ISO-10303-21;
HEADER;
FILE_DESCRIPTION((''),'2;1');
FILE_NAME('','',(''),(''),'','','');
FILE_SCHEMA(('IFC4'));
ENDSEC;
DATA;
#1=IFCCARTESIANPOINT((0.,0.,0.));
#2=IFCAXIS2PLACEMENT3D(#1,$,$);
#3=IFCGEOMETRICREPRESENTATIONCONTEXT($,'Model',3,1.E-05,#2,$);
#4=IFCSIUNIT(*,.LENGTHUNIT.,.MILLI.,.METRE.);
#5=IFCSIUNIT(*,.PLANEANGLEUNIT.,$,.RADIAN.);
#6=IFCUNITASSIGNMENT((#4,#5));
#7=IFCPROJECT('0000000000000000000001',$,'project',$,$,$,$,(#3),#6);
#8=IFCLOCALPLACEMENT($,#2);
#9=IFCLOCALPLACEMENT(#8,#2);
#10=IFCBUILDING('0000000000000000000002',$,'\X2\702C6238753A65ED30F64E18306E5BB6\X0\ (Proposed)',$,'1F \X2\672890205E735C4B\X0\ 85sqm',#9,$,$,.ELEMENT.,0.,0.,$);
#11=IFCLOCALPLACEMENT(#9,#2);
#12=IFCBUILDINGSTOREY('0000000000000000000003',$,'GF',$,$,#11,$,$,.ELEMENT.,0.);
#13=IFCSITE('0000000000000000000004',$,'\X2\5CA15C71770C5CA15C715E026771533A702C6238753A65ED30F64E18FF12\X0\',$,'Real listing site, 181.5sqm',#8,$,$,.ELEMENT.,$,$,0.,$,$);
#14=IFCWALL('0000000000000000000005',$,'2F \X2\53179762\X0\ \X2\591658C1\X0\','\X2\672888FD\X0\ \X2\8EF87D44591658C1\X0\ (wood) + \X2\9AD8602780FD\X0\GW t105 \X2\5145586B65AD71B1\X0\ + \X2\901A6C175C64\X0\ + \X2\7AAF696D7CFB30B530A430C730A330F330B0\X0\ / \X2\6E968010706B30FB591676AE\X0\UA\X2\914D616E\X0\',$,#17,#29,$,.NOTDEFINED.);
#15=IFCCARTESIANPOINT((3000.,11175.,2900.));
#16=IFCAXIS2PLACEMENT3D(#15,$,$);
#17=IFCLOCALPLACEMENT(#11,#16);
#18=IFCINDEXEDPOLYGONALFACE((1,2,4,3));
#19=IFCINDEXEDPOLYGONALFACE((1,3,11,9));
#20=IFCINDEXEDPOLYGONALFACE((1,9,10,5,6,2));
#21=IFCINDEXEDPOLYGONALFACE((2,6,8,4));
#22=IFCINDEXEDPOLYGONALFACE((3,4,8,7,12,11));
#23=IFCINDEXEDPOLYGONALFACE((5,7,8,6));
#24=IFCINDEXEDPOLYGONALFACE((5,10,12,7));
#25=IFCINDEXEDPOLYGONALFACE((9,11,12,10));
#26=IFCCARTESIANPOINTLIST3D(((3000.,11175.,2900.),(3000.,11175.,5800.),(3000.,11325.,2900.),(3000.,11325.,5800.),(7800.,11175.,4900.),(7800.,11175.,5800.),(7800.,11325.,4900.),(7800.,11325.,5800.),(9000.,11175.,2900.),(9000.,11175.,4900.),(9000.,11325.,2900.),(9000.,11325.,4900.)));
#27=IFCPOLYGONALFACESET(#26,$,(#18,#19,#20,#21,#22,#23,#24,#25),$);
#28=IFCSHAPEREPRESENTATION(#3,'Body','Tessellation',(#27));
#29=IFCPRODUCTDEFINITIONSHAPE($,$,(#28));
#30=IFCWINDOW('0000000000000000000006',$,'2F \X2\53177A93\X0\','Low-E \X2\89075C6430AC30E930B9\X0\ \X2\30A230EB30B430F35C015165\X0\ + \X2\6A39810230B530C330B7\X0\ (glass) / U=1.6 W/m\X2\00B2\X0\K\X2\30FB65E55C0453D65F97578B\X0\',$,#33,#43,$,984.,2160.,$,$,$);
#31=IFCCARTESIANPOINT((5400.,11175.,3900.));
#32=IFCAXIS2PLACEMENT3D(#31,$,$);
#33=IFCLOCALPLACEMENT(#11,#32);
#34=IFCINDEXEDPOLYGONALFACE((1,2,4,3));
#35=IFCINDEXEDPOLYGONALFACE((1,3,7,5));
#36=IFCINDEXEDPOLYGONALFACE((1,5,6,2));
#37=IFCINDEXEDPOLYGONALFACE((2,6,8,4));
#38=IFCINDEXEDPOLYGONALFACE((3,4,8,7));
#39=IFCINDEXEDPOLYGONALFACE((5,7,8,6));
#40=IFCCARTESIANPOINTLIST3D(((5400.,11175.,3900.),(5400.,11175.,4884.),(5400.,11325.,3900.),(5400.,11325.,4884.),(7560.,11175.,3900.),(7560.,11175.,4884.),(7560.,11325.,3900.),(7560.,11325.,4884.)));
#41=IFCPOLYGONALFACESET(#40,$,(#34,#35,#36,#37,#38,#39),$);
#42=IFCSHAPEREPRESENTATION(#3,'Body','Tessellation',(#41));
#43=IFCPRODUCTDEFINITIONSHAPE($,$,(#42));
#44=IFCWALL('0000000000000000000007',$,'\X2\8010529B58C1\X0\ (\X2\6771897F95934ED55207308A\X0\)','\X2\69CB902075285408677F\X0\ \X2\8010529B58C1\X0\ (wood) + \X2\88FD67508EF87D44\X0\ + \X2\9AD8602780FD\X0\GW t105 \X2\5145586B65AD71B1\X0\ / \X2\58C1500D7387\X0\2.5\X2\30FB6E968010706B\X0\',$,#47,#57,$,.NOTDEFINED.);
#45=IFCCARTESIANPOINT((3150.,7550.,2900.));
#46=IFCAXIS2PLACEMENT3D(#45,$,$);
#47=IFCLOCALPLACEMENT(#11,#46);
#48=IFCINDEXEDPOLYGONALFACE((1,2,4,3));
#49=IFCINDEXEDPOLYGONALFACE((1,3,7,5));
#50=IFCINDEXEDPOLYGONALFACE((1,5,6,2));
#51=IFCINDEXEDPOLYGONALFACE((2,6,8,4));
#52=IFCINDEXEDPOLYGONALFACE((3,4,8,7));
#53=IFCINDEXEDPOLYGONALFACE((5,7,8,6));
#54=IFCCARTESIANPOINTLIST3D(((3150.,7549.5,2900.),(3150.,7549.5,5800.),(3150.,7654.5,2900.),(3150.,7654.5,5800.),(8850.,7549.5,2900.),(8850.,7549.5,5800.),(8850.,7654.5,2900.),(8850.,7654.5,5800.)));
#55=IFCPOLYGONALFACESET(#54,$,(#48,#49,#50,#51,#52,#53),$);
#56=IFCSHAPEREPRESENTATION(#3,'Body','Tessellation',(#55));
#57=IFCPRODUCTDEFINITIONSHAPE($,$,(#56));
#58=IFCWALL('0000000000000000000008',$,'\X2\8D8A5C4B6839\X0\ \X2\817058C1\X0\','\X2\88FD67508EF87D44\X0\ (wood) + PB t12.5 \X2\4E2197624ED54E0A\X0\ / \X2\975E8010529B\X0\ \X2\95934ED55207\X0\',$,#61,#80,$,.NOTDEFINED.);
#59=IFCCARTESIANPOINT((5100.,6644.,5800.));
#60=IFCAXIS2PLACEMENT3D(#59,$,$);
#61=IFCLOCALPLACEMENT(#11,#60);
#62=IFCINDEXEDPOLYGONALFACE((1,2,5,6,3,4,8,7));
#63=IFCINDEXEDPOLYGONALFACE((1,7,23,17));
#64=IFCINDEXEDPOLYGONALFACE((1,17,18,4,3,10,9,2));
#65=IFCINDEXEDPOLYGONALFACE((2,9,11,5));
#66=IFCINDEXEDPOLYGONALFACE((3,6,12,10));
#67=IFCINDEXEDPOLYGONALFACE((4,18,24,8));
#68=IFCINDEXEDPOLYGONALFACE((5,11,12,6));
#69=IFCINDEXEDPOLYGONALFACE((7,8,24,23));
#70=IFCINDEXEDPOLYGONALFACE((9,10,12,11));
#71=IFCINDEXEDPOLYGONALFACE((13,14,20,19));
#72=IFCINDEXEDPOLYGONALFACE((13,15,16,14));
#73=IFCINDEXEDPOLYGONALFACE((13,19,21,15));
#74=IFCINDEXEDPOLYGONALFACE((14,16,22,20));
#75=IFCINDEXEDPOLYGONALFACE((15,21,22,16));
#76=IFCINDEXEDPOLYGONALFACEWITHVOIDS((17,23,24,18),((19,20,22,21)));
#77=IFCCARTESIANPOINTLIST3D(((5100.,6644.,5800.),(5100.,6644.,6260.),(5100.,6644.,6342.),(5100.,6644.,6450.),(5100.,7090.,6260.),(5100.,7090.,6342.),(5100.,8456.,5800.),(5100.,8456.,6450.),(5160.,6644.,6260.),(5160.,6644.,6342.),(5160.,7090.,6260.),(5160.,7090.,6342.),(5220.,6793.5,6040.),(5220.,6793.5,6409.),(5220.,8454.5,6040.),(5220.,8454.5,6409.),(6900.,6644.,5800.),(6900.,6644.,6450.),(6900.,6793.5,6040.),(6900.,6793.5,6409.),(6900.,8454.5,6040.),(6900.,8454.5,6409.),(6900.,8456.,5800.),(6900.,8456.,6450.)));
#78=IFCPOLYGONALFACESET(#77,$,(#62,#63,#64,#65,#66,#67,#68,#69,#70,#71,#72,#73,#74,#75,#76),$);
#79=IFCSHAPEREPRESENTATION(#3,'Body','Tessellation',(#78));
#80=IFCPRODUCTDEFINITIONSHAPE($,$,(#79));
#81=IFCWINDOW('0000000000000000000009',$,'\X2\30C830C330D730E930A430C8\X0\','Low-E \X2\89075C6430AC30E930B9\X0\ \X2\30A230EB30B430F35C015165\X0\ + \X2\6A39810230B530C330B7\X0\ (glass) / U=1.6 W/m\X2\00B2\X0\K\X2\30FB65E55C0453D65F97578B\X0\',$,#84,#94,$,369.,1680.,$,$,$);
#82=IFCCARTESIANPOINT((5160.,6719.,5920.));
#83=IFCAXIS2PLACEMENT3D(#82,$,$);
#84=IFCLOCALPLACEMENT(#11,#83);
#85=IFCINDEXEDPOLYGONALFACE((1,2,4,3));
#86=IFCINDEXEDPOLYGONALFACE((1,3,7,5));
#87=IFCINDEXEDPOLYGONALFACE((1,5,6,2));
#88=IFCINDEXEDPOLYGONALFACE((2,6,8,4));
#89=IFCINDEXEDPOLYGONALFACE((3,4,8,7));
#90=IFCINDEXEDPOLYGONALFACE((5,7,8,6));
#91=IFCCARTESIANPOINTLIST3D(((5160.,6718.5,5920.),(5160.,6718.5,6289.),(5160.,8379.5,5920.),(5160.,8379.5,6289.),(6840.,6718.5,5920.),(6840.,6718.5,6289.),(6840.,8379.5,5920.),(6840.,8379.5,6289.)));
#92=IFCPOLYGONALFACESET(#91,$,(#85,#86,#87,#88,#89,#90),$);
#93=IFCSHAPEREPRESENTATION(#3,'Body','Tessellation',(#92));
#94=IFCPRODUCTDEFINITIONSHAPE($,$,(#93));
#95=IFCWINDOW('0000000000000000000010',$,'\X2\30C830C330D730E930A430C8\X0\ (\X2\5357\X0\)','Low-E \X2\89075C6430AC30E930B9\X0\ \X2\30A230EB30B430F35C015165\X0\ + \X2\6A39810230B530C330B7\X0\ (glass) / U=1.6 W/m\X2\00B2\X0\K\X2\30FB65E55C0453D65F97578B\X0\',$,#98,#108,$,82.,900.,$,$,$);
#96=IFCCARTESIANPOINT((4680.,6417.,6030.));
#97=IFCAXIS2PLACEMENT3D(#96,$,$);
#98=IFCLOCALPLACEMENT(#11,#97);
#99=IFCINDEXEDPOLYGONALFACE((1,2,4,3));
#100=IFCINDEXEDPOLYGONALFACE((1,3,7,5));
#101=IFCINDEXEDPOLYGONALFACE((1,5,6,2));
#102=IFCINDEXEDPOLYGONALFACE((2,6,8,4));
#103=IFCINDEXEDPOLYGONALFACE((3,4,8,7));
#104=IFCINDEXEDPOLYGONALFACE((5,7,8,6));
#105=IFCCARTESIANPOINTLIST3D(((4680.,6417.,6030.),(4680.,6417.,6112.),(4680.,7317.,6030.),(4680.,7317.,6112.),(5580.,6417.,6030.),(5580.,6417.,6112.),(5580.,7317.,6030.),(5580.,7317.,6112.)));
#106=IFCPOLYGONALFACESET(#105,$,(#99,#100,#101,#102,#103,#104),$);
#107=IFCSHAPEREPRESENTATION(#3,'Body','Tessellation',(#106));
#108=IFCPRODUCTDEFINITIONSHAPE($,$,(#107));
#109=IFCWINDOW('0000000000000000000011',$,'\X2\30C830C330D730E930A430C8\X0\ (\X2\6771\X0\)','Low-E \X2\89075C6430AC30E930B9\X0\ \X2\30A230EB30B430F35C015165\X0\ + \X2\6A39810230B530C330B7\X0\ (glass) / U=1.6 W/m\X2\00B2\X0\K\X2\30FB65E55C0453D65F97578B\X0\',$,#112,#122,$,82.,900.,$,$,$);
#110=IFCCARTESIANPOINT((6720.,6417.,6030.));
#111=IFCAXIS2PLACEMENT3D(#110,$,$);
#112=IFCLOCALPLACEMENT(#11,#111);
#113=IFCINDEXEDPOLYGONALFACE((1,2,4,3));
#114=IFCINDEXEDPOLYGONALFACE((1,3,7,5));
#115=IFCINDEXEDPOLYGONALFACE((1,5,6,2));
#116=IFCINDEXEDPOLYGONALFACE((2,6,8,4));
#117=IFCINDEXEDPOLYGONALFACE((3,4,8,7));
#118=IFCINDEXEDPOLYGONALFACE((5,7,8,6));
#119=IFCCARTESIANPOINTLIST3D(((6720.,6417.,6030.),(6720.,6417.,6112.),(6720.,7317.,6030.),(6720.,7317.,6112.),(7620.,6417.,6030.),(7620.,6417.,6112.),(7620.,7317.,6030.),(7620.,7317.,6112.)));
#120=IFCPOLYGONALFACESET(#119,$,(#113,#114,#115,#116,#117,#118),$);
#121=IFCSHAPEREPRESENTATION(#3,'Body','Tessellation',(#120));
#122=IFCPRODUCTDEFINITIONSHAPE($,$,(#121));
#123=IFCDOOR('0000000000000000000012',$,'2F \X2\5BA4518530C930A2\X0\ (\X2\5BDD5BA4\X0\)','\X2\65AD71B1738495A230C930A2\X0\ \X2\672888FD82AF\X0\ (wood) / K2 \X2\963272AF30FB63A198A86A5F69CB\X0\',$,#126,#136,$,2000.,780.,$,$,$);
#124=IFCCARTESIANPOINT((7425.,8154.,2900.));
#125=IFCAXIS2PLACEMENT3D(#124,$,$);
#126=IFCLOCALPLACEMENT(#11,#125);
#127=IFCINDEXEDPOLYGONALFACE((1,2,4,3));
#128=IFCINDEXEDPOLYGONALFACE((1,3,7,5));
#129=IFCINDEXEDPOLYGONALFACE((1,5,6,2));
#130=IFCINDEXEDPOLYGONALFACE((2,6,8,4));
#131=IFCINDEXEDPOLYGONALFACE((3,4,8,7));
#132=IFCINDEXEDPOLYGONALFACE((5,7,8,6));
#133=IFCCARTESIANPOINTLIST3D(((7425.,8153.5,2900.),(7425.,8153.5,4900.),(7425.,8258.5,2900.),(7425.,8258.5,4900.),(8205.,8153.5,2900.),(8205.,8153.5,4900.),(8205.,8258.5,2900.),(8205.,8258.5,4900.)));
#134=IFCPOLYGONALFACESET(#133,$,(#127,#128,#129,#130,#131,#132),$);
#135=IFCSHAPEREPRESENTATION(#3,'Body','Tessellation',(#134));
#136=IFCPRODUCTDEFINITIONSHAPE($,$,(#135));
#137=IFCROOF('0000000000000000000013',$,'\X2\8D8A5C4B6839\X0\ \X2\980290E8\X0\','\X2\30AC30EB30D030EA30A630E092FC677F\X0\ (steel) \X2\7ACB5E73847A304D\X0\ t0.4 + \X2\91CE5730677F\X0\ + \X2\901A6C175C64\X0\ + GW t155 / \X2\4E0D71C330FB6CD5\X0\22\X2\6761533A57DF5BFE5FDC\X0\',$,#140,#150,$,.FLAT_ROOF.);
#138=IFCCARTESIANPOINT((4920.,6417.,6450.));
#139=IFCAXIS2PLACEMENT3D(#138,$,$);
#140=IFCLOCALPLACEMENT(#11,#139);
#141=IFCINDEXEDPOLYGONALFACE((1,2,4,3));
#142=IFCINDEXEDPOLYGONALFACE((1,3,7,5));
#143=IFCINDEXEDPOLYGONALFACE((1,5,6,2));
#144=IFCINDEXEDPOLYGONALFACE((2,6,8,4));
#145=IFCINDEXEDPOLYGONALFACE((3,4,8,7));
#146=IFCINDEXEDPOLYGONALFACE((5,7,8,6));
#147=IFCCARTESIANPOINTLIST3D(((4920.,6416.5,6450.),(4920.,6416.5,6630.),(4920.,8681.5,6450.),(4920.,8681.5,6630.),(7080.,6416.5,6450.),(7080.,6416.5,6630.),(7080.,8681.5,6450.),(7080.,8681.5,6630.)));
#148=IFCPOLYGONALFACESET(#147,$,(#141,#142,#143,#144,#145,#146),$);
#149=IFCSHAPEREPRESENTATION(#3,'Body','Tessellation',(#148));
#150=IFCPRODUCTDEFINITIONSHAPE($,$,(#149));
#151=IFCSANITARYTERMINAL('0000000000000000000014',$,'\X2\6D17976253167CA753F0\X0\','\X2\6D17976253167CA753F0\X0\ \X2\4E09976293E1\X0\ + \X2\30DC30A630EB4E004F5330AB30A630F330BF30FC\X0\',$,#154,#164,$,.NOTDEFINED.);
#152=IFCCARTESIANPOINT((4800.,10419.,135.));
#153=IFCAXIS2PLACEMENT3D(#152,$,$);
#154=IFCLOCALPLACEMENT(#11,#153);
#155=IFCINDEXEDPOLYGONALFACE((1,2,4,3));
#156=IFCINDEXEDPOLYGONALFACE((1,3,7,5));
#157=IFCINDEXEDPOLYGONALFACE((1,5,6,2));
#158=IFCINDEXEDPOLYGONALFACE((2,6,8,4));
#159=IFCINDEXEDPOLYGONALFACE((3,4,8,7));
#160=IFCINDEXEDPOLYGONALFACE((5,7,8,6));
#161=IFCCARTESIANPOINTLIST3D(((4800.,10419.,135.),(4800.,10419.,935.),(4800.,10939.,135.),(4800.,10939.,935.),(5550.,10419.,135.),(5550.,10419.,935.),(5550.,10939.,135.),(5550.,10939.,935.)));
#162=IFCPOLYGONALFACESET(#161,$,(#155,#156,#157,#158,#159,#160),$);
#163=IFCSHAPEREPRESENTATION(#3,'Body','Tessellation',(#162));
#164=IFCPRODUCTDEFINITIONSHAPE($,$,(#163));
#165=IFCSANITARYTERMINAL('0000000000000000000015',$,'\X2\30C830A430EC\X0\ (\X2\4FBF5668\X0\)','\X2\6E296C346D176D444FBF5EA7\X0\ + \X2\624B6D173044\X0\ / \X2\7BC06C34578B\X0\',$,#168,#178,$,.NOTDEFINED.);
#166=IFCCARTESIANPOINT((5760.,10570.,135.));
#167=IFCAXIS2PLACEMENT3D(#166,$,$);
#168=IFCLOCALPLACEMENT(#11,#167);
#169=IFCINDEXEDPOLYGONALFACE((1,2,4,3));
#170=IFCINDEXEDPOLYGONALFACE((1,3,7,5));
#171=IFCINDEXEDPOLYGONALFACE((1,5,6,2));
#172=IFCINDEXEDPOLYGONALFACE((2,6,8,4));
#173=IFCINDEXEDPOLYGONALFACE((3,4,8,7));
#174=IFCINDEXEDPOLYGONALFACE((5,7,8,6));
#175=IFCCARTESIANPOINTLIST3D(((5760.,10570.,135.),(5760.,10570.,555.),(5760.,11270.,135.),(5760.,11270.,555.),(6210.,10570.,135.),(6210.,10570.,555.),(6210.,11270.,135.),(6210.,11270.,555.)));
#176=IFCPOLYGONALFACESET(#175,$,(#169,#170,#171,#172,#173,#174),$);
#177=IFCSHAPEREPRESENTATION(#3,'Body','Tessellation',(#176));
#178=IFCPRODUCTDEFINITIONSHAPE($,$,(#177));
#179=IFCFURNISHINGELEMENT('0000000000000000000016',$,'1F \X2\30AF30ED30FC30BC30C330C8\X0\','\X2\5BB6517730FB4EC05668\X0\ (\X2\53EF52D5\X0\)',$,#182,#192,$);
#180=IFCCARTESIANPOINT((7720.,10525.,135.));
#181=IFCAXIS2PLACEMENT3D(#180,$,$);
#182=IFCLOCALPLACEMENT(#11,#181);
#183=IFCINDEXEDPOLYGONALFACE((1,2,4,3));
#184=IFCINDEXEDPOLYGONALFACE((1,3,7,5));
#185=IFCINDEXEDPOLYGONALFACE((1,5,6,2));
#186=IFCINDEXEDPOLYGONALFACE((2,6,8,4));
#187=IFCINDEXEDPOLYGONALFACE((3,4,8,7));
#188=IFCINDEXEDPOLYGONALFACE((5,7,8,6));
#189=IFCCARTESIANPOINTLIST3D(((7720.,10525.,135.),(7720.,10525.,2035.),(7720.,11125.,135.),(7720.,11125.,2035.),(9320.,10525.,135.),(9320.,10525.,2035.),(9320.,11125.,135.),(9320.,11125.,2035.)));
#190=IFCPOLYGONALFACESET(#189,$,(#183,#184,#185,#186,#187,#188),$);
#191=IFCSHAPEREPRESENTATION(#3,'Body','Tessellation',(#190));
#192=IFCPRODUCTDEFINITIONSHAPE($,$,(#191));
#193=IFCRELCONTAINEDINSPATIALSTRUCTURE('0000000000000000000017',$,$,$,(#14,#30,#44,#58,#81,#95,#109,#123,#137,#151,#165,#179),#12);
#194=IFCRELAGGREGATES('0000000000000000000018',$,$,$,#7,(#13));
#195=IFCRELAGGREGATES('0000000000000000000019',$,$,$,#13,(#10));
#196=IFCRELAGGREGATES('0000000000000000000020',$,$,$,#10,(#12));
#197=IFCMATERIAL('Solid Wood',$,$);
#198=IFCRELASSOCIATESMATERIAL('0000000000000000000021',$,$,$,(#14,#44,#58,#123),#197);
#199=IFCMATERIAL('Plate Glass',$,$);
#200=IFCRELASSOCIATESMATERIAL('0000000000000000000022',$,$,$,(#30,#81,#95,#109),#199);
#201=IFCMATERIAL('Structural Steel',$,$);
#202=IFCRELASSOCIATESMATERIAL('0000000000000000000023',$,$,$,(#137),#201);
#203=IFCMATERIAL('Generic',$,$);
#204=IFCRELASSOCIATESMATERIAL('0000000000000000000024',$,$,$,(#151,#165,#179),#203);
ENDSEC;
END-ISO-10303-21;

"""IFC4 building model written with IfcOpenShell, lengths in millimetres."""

from ifc_helpers import new_model, si_unit, frame, frame_2d, origin, place, context, project, spatial, rectangle, extrude, material, element, fill, save


model = new_model("IFC4")

# Units and contexts
model_context = context("Model", 3, precision=1e-05, world=origin())
ifc_project = project(units=[si_unit("LENGTHUNIT", "METRE", prefix="MILLI"), si_unit("PLANEANGLEUNIT", "RADIAN")], contexts=[model_context])

# Site, building, storey
site_placement = place(None, origin())
site = spatial("IfcSite", under=ifc_project, at=site_placement, Name="岡山県岡山市東区瀬戸町旭ヶ丘２", ObjectType="Real listing site, 181.5sqm", CompositionType="ELEMENT", RefElevation=0.0)
building_placement = place(site_placement, origin())
building = spatial("IfcBuilding", under=site, at=building_placement, Name="瀬戸町旭ヶ丘の家 (Proposed)", ObjectType="1F 木造平屋 85sqm", CompositionType="ELEMENT", ElevationOfRefHeight=0.0, ElevationOfTerrain=0.0)
storey_placement = place(building_placement, origin())
storey = spatial("IfcBuildingStorey", under=building, at=storey_placement, Name="GF", CompositionType="ELEMENT", Elevation=0.0)

# Wall, opening, window
ifc_material_1 = material(Name="Solid Wood")
wall_1_placement = place(storey_placement, frame((3000.0, 11175.0, 2900.0)))
wall_1 = element("IfcWall", 1, at=wall_1_placement, inside=storey, material=ifc_material_1, Name="2F 北面 外壁", Description="木製 軸組外壁 (wood) + 高性能GW t105 充填断熱 + 通気層 + 窯業系サイディング / 準耐火・外皮UA配慮", PredefinedType="NOTDEFINED", context=model_context, shape_type="SweptSolid", body=[
    extrude(rectangle(XDim=6000.0, YDim=150.0, at=frame_2d((3000.0, 75.0))), frame((3000.0, 11175.0, 2900.0)), (0.0, 0.0, 1.0), 2900.0),
])
opening_1_placement = place(storey_placement, frame((5400.0, 11175.0, 3900.0)))
opening_1 = element("IfcOpeningElement", 2, at=opening_1_placement, cuts=wall_1, PredefinedType="NOTDEFINED", context=model_context, shape_type="SweptSolid", body=[
    extrude(rectangle(XDim=2160.0, YDim=150.0, at=frame_2d((1080.0, 75.0))), frame((5400.0, 11175.0, 3900.0)), (0.0, 0.0, 1.0), 984.0),
])
ifc_material_2 = material(Name="Plate Glass")
window_1_placement = place(storey_placement, frame((5400.0, 11175.0, 3900.0)))
window_1 = element("IfcWindow", 3, at=window_1_placement, inside=storey, material=ifc_material_2, Name="2F 北窓", Description="Low-E 複層ガラス アルゴン封入 + 樹脂サッシ (glass) / U=1.6 W/m²K・日射取得型", OverallHeight=984.0, OverallWidth=2160.0, context=model_context, shape_type="SweptSolid", body=[
    extrude(rectangle(XDim=2160.0, YDim=150.0, at=frame_2d((1080.0, 75.0))), frame((5400.0, 11175.0, 3900.0)), (0.0, 0.0, 1.0), 984.0),
])
fill(opening_1, window_1)

# Wall
wall_2_placement = place(storey_placement, frame((3150.0, 7550.0, 2900.0)))
element("IfcWall", 4, at=wall_2_placement, inside=storey, material=ifc_material_1, Name="耐力壁 (東西間仕切り)", Description="構造用合板 耐力壁 (wood) + 製材軸組 + 高性能GW t105 充填断熱 / 壁倍率2.5・準耐火", PredefinedType="NOTDEFINED", context=model_context, shape_type="SweptSolid", body=[
    extrude(rectangle(XDim=5700.0, YDim=105.0, at=frame_2d((2850.0, 52.0))), frame((3150.0, 7550.0, 2900.0)), (0.0, 0.0, 1.0), 2900.0),
])

# Wall, openings, windows
wall_3_placement = place(storey_placement, frame((5100.0, 6644.0, 5800.0)))
wall_3 = element("IfcWall", 5, at=wall_3_placement, inside=storey, material=ifc_material_1, Name="越屋根 腰壁", Description="製材軸組 (wood) + PB t12.5 両面仕上 / 非耐力 間仕切", PredefinedType="NOTDEFINED", context=model_context, shape_type="SweptSolid", body=[
    extrude(rectangle(XDim=1800.0, YDim=1812.0, at=frame_2d((900.0, 906.0))), frame((5100.0, 6644.0, 5800.0)), (0.0, 0.0, 1.0), 650.0),
])
opening_2_placement = place(storey_placement, frame((5160.0, 6719.0, 5920.0)))
opening_2 = element("IfcOpeningElement", 6, at=opening_2_placement, cuts=wall_3, PredefinedType="NOTDEFINED", context=model_context, shape_type="SweptSolid", body=[
    extrude(rectangle(XDim=1680.0, YDim=1661.0, at=frame_2d((840.0, 830.0))), frame((5160.0, 6719.0, 5920.0)), (0.0, 0.0, 1.0), 369.0),
])
opening_3_placement = place(storey_placement, frame((4680.0, 6417.0, 6030.0)))
opening_3 = element("IfcOpeningElement", 7, at=opening_3_placement, cuts=wall_3, PredefinedType="NOTDEFINED", context=model_context, shape_type="SweptSolid", body=[
    extrude(rectangle(XDim=900.0, YDim=900.0, at=frame_2d((450.0, 450.0))), frame((4680.0, 6417.0, 6030.0)), (0.0, 0.0, 1.0), 82.0),
])
opening_4_placement = place(storey_placement, frame((6720.0, 6417.0, 6030.0)))
opening_4 = element("IfcOpeningElement", 8, at=opening_4_placement, cuts=wall_3, PredefinedType="NOTDEFINED", context=model_context, shape_type="SweptSolid", body=[
    extrude(rectangle(XDim=900.0, YDim=900.0, at=frame_2d((450.0, 450.0))), frame((6720.0, 6417.0, 6030.0)), (0.0, 0.0, 1.0), 82.0),
])
window_2_placement = place(storey_placement, frame((5160.0, 6719.0, 5920.0)))
window_2 = element("IfcWindow", 9, at=window_2_placement, inside=storey, material=ifc_material_2, Name="トップライト", Description="Low-E 複層ガラス アルゴン封入 + 樹脂サッシ (glass) / U=1.6 W/m²K・日射取得型", OverallHeight=369.0, OverallWidth=1680.0, context=model_context, shape_type="SweptSolid", body=[
    extrude(rectangle(XDim=1680.0, YDim=1661.0, at=frame_2d((840.0, 830.0))), frame((5160.0, 6719.0, 5920.0)), (0.0, 0.0, 1.0), 369.0),
])
fill(opening_2, window_2)
window_3_placement = place(storey_placement, frame((4680.0, 6417.0, 6030.0)))
window_3 = element("IfcWindow", 10, at=window_3_placement, inside=storey, material=ifc_material_2, Name="トップライト (南)", Description="Low-E 複層ガラス アルゴン封入 + 樹脂サッシ (glass) / U=1.6 W/m²K・日射取得型", OverallHeight=82.0, OverallWidth=900.0, context=model_context, shape_type="SweptSolid", body=[
    extrude(rectangle(XDim=900.0, YDim=900.0, at=frame_2d((450.0, 450.0))), frame((4680.0, 6417.0, 6030.0)), (0.0, 0.0, 1.0), 82.0),
])
fill(opening_3, window_3)
window_4_placement = place(storey_placement, frame((6720.0, 6417.0, 6030.0)))
window_4 = element("IfcWindow", 11, at=window_4_placement, inside=storey, material=ifc_material_2, Name="トップライト (東)", Description="Low-E 複層ガラス アルゴン封入 + 樹脂サッシ (glass) / U=1.6 W/m²K・日射取得型", OverallHeight=82.0, OverallWidth=900.0, context=model_context, shape_type="SweptSolid", body=[
    extrude(rectangle(XDim=900.0, YDim=900.0, at=frame_2d((450.0, 450.0))), frame((6720.0, 6417.0, 6030.0)), (0.0, 0.0, 1.0), 82.0),
])
fill(opening_4, window_4)

# Door
door_placement = place(storey_placement, frame((7425.0, 8154.0, 2900.0)))
element("IfcDoor", 12, at=door_placement, inside=storey, material=ifc_material_1, Name="2F 室内ドア (寝室)", Description="断熱玄関ドア 木製芯 (wood) / K2 防犯・採風機構", OverallHeight=2000.0, OverallWidth=780.0, context=model_context, shape_type="SweptSolid", body=[
    extrude(rectangle(XDim=780.0, YDim=105.0, at=frame_2d((390.0, 52.0))), frame((7425.0, 8154.0, 2900.0)), (0.0, 0.0, 1.0), 2000.0),
])

# Roof
ifc_material_3 = material(Name="Structural Steel")
roof_placement = place(storey_placement, frame((4920.0, 6417.0, 6450.0)))
element("IfcRoof", 13, at=roof_placement, inside=storey, material=ifc_material_3, Name="越屋根 頂部", Description="ガルバリウム鋼板 (steel) 立平葺き t0.4 + 野地板 + 通気層 + GW t155 / 不燃・法22条区域対応", PredefinedType="FLAT_ROOF", context=model_context, shape_type="SweptSolid", body=[
    extrude(rectangle(XDim=2160.0, YDim=2265.0, at=frame_2d((1080.0, 1132.0))), frame((4920.0, 6417.0, 6450.0)), (0.0, 0.0, 1.0), 180.0),
])

# Sanitary terminals
ifc_material_4 = material(Name="Generic")
sanitary_terminal_1_placement = place(storey_placement, frame((4800.0, 10419.0, 135.0)))
element("IfcSanitaryTerminal", 14, at=sanitary_terminal_1_placement, inside=storey, material=ifc_material_4, Name="洗面化粧台", Description="洗面化粧台 三面鏡 + ボウル一体カウンター", PredefinedType="NOTDEFINED", context=model_context, shape_type="SweptSolid", body=[
    extrude(rectangle(XDim=750.0, YDim=520.0, at=frame_2d((375.0, 260.0))), frame((4800.0, 10419.0, 135.0)), (0.0, 0.0, 1.0), 800.0),
])
sanitary_terminal_2_placement = place(storey_placement, frame((5760.0, 10570.0, 135.0)))
element("IfcSanitaryTerminal", 15, at=sanitary_terminal_2_placement, inside=storey, material=ifc_material_4, Name="トイレ (便器)", Description="温水洗浄便座 + 手洗い / 節水型", PredefinedType="NOTDEFINED", context=model_context, shape_type="SweptSolid", body=[
    extrude(rectangle(XDim=450.0, YDim=700.0, at=frame_2d((225.0, 350.0))), frame((5760.0, 10570.0, 135.0)), (0.0, 0.0, 1.0), 420.0),
])

# Furnishing element
furnishing_1_placement = place(storey_placement, frame((7720.0, 10525.0, 135.0)))
element("IfcFurnishingElement", 16, at=furnishing_1_placement, inside=storey, material=ifc_material_4, Name="1F クローゼット", Description="家具・什器 (可動)", context=model_context, shape_type="SweptSolid", body=[
    extrude(rectangle(XDim=1600.0, YDim=600.0, at=frame_2d((800.0, 300.0))), frame((7720.0, 10525.0, 135.0)), (0.0, 0.0, 1.0), 1900.0),
])

save(model, "model.ifc")
